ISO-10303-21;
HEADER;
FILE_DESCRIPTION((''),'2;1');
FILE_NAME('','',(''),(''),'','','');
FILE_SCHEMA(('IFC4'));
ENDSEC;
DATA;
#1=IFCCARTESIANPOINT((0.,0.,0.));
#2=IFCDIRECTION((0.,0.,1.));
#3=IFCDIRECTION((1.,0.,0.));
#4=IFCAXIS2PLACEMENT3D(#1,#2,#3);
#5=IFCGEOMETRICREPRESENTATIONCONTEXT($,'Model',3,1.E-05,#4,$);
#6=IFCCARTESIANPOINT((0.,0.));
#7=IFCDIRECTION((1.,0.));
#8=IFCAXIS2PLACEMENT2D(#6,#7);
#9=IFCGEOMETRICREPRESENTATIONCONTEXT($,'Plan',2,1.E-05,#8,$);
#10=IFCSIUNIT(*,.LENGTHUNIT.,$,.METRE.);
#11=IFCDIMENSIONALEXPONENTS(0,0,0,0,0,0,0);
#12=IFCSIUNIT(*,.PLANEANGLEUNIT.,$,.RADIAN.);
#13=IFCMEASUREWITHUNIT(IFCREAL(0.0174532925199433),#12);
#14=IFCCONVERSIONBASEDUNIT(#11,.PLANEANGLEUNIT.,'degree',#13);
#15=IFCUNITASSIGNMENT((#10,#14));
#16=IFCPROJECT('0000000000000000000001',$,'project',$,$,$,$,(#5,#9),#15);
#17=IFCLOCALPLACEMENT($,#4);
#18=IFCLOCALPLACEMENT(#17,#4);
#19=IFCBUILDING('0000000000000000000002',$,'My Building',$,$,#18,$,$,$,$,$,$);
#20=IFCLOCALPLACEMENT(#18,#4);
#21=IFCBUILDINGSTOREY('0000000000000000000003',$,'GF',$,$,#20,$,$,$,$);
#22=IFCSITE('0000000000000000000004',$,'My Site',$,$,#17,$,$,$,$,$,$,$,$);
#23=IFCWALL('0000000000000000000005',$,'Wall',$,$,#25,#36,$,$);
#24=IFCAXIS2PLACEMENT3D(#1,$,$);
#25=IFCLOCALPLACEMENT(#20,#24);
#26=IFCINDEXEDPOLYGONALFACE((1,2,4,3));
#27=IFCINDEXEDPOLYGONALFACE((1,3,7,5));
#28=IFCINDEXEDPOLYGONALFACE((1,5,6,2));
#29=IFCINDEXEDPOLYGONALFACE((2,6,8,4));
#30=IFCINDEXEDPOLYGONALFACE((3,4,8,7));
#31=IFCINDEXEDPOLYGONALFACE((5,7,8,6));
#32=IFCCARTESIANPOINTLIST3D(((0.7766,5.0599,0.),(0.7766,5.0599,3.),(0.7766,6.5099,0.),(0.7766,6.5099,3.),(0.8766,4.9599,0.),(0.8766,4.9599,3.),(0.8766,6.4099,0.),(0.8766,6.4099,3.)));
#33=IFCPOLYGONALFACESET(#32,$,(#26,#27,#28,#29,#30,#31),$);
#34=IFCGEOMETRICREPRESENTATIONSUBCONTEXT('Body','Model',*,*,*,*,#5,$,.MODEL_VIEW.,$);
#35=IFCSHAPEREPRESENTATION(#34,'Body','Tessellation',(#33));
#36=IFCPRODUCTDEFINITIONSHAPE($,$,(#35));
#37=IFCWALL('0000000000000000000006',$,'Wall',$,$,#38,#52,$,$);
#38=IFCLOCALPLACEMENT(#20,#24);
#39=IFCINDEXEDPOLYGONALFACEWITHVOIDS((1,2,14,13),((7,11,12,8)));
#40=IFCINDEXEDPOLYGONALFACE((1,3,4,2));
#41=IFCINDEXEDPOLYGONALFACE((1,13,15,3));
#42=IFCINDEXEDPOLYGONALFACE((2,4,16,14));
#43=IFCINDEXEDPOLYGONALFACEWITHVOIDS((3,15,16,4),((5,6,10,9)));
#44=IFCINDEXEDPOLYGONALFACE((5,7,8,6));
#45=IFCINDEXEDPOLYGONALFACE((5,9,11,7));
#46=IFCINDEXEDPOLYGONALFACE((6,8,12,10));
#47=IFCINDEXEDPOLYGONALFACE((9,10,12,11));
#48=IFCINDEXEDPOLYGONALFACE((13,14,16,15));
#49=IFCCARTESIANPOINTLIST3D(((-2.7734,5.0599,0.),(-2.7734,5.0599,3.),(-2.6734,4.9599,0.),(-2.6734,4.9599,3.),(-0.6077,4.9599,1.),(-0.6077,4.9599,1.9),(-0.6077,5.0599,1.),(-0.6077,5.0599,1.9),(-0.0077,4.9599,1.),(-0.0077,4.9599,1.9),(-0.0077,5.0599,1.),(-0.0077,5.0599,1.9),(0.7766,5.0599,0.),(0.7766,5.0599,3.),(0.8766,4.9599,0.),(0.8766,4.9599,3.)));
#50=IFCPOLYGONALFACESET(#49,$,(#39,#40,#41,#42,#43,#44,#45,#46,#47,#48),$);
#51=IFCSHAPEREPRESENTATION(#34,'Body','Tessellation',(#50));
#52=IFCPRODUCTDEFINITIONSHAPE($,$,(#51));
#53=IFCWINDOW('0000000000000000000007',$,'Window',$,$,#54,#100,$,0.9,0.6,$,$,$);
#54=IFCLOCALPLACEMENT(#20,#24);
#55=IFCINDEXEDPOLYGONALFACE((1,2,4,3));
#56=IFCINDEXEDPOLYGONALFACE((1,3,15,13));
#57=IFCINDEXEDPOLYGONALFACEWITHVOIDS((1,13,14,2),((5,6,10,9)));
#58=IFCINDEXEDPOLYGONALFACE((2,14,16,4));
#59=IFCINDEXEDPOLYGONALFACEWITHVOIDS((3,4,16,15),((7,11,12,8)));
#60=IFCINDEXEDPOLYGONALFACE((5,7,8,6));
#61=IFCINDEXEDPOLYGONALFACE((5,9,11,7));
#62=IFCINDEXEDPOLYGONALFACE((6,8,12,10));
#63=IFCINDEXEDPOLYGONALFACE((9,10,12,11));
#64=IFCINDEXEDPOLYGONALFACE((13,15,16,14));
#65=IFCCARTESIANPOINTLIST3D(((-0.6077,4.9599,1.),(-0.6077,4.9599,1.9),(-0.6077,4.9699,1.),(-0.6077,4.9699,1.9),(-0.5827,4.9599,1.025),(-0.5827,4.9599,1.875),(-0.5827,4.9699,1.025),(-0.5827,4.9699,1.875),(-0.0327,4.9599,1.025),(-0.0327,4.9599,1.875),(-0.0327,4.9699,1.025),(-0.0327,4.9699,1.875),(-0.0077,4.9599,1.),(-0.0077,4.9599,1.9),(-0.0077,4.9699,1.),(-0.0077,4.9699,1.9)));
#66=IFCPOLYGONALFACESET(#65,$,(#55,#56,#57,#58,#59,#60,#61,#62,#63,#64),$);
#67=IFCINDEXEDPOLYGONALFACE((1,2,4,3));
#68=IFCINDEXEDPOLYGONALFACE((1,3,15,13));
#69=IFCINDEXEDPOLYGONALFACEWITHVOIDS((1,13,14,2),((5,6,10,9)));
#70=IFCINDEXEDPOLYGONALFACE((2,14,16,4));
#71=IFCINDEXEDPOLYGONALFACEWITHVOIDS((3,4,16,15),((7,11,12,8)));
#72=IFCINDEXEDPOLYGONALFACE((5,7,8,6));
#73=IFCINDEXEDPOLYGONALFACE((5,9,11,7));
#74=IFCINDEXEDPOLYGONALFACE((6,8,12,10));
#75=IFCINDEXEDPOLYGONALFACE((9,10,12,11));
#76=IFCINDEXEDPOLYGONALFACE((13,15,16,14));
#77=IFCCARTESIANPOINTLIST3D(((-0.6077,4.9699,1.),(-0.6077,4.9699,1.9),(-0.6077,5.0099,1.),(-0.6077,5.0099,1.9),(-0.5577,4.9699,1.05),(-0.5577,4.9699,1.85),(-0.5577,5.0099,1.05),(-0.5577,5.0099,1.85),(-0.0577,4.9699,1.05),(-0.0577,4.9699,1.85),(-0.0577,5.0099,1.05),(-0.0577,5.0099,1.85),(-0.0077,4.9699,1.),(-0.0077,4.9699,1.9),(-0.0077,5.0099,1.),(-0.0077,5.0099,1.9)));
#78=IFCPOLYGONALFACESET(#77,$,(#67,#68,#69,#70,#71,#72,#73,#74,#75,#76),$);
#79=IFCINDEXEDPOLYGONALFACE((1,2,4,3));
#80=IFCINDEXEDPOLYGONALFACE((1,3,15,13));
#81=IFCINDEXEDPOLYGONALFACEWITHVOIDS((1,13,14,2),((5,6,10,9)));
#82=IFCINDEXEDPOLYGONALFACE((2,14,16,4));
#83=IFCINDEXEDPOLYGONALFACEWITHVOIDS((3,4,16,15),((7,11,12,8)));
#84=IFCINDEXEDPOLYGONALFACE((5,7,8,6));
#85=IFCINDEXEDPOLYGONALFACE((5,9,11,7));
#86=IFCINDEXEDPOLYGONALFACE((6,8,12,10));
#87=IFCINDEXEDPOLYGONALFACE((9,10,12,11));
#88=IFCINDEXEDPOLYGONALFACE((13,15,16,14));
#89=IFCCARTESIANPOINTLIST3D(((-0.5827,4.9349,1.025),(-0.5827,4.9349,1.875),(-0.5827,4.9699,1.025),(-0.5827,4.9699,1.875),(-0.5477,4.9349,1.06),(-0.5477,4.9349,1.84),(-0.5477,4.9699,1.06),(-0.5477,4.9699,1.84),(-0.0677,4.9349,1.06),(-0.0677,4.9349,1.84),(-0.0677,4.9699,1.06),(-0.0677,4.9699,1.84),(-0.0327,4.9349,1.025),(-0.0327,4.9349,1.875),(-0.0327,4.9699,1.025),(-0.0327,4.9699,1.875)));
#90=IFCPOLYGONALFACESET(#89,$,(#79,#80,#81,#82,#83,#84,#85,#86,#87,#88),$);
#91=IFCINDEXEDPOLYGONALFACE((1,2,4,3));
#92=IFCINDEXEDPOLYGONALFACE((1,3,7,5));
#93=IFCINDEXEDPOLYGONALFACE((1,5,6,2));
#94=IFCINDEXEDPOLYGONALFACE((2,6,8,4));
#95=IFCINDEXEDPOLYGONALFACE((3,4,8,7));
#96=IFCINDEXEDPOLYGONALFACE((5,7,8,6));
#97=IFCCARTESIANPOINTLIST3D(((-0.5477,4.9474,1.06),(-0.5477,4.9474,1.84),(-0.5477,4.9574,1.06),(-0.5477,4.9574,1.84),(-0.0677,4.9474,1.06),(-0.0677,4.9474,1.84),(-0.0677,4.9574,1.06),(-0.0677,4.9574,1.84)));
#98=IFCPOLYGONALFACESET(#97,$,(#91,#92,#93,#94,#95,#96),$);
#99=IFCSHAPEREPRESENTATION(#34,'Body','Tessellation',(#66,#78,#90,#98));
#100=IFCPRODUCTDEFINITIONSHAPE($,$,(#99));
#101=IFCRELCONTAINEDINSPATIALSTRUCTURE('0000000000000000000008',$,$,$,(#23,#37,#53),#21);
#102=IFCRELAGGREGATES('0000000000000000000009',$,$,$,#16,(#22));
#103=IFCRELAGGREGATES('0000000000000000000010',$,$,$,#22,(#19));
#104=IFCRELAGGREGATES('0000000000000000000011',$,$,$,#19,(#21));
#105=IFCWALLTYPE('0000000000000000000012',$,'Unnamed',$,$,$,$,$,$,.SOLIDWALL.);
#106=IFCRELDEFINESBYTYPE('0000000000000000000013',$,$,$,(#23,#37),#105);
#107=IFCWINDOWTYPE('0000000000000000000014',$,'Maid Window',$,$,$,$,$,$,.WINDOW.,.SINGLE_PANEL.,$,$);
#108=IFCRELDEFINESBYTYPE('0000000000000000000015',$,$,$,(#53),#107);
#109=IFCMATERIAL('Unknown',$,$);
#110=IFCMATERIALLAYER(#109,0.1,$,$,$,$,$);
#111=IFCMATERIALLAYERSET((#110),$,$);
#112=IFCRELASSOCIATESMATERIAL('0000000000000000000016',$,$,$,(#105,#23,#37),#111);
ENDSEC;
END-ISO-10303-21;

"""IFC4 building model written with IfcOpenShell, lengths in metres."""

from ifc_helpers import new_model, entity, si_unit, converted_unit, frame, origin_with_axes, origin_2d_with_axis, place, context, subcontext, project, spatial, line, indexed_curve, outline, extrude, shape, source, transform, mapped, material, layer, layer_set, layer_usage, type_object, type_shapes, element, fill, save


model = new_model("IFC4")

# Units and contexts
model_context = context("Model", 3, precision=1e-05, world=origin_with_axes())
plan_context = context("Plan", 2, precision=1e-05, world=origin_2d_with_axis())
body_context_1 = subcontext(model_context, "Body", "Model", "MODEL_VIEW")
body_context_2 = subcontext(plan_context, "Body", "Plan", "PLAN_VIEW")
ifc_project = project(units=[si_unit("LENGTHUNIT", "METRE"), converted_unit("PLANEANGLEUNIT", "degree", entity("IfcReal", 0.0174532925199433), si_unit("PLANEANGLEUNIT", "RADIAN"), dimensions=[0, 0, 0, 0, 0, 0, 0])], contexts=[model_context, plan_context])

# Site, building, storey
site_placement = place(None, origin_with_axes())
site = spatial("IfcSite", under=ifc_project, at=site_placement, Name="My Site")
building_placement = place(site_placement, origin_with_axes())
building = spatial("IfcBuilding", under=site, at=building_placement, Name="My Building")
storey_placement = place(building_placement, origin_with_axes())
storey = spatial("IfcBuildingStorey", under=building, at=storey_placement, Name="GF")

# Shared definitions
ifc_material_1 = material(Name="Unknown")

# Wall
ifc_layer_1 = layer(ifc_material_1, 0.1)
ifc_layer_set_1 = layer_set([ifc_layer_1])
wall_type = type_object("IfcWallType", Name="Unnamed", PredefinedType="SOLIDWALL", material=ifc_layer_set_1)
ifc_layer_usage_1 = layer_usage(ifc_layer_set_1, "AXIS2", "POSITIVE", 0.0)
wall_1_placement = place(storey_placement, frame((0.7766, 6.5099, 0.0), z_axis=(0.0, 0.0, 1.0), x_axis=(0.0, -1.0, 0.0)))
element("IfcWall", 1, at=wall_1_placement, inside=storey, type_object=wall_type, material=ifc_layer_usage_1, Name="Wall", context=body_context_1, shape_type="SweptSolid", body=[
    extrude(outline(indexed_curve([(0.0, 0.0), (0.1, 0.1), (1.55, 0.1), (1.45, 0.0)], segments=[line(1, 2, 3, 4, 1)])), origin_with_axes(), (0.0, 0.0, 1.0), 3.0),
])

# Wall, opening, window
ifc_layer_usage_2 = layer_usage(ifc_layer_set_1, "AXIS2", "POSITIVE", 0.0)
wall_2_placement = place(storey_placement, frame((0.7766, 5.0599, 0.0), z_axis=(0.0, 0.0, 1.0), x_axis=(-1.0, 0.0, 0.0)))
wall_2 = element("IfcWall", 2, at=wall_2_placement, inside=storey, type_object=wall_type, material=ifc_layer_usage_2, Name="Wall", context=body_context_1, shape_type="SweptSolid", body=[
    extrude(outline(indexed_curve([(0.0, 0.0), (-0.1, 0.1), (3.45, 0.1), (3.55, 0.0)], segments=[line(1, 2, 3, 4, 1)])), origin_with_axes(), (0.0, 0.0, 1.0), 3.0),
])
shared_shape_1 = source(origin_with_axes(), body_context_1, "Body", "SweptSolid", [
    extrude(outline(indexed_curve([(0.0, 0.0), (0.6, 0.0), (0.6, 0.9), (0.0, 0.9)], segments=[line(1, 2, 3, 4, 1)])), frame((0.0, -0.6, 0.0), z_axis=(0.0, -1.0, 0.0), x_axis=(1.0, 0.0, 0.0)), (0.0, 0.0, -1.0), 1.2),
])
opening_1_placement = place(wall_2_placement, frame((0.7843, 0.0, 1.0), z_axis=(0.0, 0.0, 1.0), x_axis=(1.0, 0.0, 0.0)))
opening_1 = element("IfcOpeningElement", 3, at=opening_1_placement, cuts=wall_2, PredefinedType="OPENING", context=body_context_1, shape_type="MappedRepresentation", body=[
    mapped(shared_shape_1, transform((0.0, 0.0, 0.0), x_axis=(1.0, 0.0, 0.0), y_axis=(0.0, 1.0, 0.0), z_axis=(0.0, 0.0, 1.0), scale=1.0)),
])
window_type_1 = type_object("IfcWindowType", Name="Maid Window", PartitioningType="SINGLE_PANEL", PredefinedType="WINDOW")
shared_shape_2 = source(origin_with_axes(), body_context_1, "Body", "SweptSolid", [
    extrude(outline(indexed_curve([(0.0, 0.0), (0.6, 0.0), (0.6, 0.9), (0.0, 0.9)], segments=[line(1, 2, 3, 4, 1)]), holes=[indexed_curve([(0.025, 0.025), (0.575, 0.025), (0.575, 0.875), (0.025, 0.875)], segments=[line(1, 2, 3, 4, 1)])]), frame((0.0, 0.09, 0.0), z_axis=(0.0, -1.0, 0.0), x_axis=(1.0, 0.0, 0.0)), (0.0, 0.0, -1.0), 0.01),
    extrude(outline(indexed_curve([(0.0, 0.0), (0.6, 0.0), (0.6, 0.9), (0.0, 0.9)], segments=[line(1, 2, 3, 4, 1)]), holes=[indexed_curve([(0.05, 0.05), (0.55, 0.05), (0.55, 0.85), (0.05, 0.85)], segments=[line(1, 2, 3, 4, 1)])]), frame((0.0, 0.05, 0.0), z_axis=(0.0, -1.0, 0.0), x_axis=(1.0, 0.0, 0.0)), (0.0, 0.0, -1.0), 0.04),
    extrude(outline(indexed_curve([(0.0, 0.0), (0.55, 0.0), (0.55, 0.85), (0.0, 0.85)], segments=[line(1, 2, 3, 4, 1)]), holes=[indexed_curve([(0.035, 0.035), (0.515, 0.035), (0.515, 0.815), (0.035, 0.815)], segments=[line(1, 2, 3, 4, 1)])]), frame((0.025, 0.09, 0.025), z_axis=(0.0, -1.0, 0.0), x_axis=(1.0, 0.0, 0.0)), (0.0, 0.0, -1.0), 0.035),
    extrude(outline(indexed_curve([(0.035, 0.035), (0.515, 0.035), (0.515, 0.815), (0.035, 0.815)], segments=[line(1, 2, 3, 4, 1)])), frame((0.025, 0.1025, 0.025), z_axis=(0.0, -1.0, 0.0), x_axis=(1.0, 0.0, 0.0)), (0.0, 0.0, -1.0), 0.01),
])
shared_shape_3 = source(origin_with_axes(), body_context_2, "Body", "Curve2D", [
    entity("IfcIndexedPolyCurve", entity("IfcCartesianPointList2D", [[0.05, 0.05], [0.55, 0.05]])),
    entity("IfcIndexedPolyCurve", entity("IfcCartesianPointList2D", [[0.0, 0.1], [0.025, 0.1], [0.025, 0.09], [0.05, 0.09], [0.05, 0.05], [0.0, 0.05]]), [entity("IfcLineIndex", [1, 2, 3, 4, 5, 6, 1])]),
    entity("IfcIndexedPolyCurve", entity("IfcCartesianPointList2D", [[0.6, 0.1], [0.575, 0.1], [0.575, 0.09], [0.55, 0.09], [0.55, 0.05], [0.6, 0.05]]), [entity("IfcLineIndex", [1, 2, 3, 4, 5, 6, 1])]),
    entity("IfcIndexedPolyCurve", entity("IfcCartesianPointList2D", [[0.025, 0.09], [0.06, 0.09], [0.06, 0.125], [0.025, 0.125]]), [entity("IfcLineIndex", [1, 2, 3, 4, 1])]),
    entity("IfcIndexedPolyCurve", entity("IfcCartesianPointList2D", [[0.575, 0.09], [0.54, 0.09], [0.54, 0.125], [0.575, 0.125]]), [entity("IfcLineIndex", [1, 2, 3, 4, 1])]),
    entity("IfcIndexedPolyCurve", entity("IfcCartesianPointList2D", [[0.06, 0.09], [0.54, 0.09]])),
    entity("IfcIndexedPolyCurve", entity("IfcCartesianPointList2D", [[0.06, 0.125], [0.54, 0.125]])),
    entity("IfcIndexedPolyCurve", entity("IfcCartesianPointList2D", [[0.06, 0.1075], [0.54, 0.1075]])),
])
type_shapes(window_type_1, [shared_shape_2, shared_shape_3])
window_1_placement = place(opening_1_placement, frame((0.0, 0.0, 0.0), z_axis=(0.0, 0.0, 1.0), x_axis=(1.0, 0.0, 0.0)))
window_1 = element("IfcWindow", 4, at=window_1_placement, inside=storey, type_object=window_type_1, Name="Window", OverallHeight=0.9, OverallWidth=0.6, shapes=[
    shape(body_context_1, "Body", "MappedRepresentation", [mapped(shared_shape_2, transform((0.0, 0.0, 0.0), x_axis=(1.0, 0.0, 0.0), y_axis=(0.0, 1.0, 0.0), z_axis=(0.0, 0.0, 1.0), scale=1.0))]),
    shape(body_context_2, "Body", "MappedRepresentation", [mapped(shared_shape_3, transform((0.0, 0.0, 0.0), x_axis=(1.0, 0.0, 0.0), y_axis=(0.0, 1.0, 0.0), z_axis=(0.0, 0.0, 1.0), scale=1.0))]),
])
fill(opening_1, window_1)

save(model, "model.ifc")
